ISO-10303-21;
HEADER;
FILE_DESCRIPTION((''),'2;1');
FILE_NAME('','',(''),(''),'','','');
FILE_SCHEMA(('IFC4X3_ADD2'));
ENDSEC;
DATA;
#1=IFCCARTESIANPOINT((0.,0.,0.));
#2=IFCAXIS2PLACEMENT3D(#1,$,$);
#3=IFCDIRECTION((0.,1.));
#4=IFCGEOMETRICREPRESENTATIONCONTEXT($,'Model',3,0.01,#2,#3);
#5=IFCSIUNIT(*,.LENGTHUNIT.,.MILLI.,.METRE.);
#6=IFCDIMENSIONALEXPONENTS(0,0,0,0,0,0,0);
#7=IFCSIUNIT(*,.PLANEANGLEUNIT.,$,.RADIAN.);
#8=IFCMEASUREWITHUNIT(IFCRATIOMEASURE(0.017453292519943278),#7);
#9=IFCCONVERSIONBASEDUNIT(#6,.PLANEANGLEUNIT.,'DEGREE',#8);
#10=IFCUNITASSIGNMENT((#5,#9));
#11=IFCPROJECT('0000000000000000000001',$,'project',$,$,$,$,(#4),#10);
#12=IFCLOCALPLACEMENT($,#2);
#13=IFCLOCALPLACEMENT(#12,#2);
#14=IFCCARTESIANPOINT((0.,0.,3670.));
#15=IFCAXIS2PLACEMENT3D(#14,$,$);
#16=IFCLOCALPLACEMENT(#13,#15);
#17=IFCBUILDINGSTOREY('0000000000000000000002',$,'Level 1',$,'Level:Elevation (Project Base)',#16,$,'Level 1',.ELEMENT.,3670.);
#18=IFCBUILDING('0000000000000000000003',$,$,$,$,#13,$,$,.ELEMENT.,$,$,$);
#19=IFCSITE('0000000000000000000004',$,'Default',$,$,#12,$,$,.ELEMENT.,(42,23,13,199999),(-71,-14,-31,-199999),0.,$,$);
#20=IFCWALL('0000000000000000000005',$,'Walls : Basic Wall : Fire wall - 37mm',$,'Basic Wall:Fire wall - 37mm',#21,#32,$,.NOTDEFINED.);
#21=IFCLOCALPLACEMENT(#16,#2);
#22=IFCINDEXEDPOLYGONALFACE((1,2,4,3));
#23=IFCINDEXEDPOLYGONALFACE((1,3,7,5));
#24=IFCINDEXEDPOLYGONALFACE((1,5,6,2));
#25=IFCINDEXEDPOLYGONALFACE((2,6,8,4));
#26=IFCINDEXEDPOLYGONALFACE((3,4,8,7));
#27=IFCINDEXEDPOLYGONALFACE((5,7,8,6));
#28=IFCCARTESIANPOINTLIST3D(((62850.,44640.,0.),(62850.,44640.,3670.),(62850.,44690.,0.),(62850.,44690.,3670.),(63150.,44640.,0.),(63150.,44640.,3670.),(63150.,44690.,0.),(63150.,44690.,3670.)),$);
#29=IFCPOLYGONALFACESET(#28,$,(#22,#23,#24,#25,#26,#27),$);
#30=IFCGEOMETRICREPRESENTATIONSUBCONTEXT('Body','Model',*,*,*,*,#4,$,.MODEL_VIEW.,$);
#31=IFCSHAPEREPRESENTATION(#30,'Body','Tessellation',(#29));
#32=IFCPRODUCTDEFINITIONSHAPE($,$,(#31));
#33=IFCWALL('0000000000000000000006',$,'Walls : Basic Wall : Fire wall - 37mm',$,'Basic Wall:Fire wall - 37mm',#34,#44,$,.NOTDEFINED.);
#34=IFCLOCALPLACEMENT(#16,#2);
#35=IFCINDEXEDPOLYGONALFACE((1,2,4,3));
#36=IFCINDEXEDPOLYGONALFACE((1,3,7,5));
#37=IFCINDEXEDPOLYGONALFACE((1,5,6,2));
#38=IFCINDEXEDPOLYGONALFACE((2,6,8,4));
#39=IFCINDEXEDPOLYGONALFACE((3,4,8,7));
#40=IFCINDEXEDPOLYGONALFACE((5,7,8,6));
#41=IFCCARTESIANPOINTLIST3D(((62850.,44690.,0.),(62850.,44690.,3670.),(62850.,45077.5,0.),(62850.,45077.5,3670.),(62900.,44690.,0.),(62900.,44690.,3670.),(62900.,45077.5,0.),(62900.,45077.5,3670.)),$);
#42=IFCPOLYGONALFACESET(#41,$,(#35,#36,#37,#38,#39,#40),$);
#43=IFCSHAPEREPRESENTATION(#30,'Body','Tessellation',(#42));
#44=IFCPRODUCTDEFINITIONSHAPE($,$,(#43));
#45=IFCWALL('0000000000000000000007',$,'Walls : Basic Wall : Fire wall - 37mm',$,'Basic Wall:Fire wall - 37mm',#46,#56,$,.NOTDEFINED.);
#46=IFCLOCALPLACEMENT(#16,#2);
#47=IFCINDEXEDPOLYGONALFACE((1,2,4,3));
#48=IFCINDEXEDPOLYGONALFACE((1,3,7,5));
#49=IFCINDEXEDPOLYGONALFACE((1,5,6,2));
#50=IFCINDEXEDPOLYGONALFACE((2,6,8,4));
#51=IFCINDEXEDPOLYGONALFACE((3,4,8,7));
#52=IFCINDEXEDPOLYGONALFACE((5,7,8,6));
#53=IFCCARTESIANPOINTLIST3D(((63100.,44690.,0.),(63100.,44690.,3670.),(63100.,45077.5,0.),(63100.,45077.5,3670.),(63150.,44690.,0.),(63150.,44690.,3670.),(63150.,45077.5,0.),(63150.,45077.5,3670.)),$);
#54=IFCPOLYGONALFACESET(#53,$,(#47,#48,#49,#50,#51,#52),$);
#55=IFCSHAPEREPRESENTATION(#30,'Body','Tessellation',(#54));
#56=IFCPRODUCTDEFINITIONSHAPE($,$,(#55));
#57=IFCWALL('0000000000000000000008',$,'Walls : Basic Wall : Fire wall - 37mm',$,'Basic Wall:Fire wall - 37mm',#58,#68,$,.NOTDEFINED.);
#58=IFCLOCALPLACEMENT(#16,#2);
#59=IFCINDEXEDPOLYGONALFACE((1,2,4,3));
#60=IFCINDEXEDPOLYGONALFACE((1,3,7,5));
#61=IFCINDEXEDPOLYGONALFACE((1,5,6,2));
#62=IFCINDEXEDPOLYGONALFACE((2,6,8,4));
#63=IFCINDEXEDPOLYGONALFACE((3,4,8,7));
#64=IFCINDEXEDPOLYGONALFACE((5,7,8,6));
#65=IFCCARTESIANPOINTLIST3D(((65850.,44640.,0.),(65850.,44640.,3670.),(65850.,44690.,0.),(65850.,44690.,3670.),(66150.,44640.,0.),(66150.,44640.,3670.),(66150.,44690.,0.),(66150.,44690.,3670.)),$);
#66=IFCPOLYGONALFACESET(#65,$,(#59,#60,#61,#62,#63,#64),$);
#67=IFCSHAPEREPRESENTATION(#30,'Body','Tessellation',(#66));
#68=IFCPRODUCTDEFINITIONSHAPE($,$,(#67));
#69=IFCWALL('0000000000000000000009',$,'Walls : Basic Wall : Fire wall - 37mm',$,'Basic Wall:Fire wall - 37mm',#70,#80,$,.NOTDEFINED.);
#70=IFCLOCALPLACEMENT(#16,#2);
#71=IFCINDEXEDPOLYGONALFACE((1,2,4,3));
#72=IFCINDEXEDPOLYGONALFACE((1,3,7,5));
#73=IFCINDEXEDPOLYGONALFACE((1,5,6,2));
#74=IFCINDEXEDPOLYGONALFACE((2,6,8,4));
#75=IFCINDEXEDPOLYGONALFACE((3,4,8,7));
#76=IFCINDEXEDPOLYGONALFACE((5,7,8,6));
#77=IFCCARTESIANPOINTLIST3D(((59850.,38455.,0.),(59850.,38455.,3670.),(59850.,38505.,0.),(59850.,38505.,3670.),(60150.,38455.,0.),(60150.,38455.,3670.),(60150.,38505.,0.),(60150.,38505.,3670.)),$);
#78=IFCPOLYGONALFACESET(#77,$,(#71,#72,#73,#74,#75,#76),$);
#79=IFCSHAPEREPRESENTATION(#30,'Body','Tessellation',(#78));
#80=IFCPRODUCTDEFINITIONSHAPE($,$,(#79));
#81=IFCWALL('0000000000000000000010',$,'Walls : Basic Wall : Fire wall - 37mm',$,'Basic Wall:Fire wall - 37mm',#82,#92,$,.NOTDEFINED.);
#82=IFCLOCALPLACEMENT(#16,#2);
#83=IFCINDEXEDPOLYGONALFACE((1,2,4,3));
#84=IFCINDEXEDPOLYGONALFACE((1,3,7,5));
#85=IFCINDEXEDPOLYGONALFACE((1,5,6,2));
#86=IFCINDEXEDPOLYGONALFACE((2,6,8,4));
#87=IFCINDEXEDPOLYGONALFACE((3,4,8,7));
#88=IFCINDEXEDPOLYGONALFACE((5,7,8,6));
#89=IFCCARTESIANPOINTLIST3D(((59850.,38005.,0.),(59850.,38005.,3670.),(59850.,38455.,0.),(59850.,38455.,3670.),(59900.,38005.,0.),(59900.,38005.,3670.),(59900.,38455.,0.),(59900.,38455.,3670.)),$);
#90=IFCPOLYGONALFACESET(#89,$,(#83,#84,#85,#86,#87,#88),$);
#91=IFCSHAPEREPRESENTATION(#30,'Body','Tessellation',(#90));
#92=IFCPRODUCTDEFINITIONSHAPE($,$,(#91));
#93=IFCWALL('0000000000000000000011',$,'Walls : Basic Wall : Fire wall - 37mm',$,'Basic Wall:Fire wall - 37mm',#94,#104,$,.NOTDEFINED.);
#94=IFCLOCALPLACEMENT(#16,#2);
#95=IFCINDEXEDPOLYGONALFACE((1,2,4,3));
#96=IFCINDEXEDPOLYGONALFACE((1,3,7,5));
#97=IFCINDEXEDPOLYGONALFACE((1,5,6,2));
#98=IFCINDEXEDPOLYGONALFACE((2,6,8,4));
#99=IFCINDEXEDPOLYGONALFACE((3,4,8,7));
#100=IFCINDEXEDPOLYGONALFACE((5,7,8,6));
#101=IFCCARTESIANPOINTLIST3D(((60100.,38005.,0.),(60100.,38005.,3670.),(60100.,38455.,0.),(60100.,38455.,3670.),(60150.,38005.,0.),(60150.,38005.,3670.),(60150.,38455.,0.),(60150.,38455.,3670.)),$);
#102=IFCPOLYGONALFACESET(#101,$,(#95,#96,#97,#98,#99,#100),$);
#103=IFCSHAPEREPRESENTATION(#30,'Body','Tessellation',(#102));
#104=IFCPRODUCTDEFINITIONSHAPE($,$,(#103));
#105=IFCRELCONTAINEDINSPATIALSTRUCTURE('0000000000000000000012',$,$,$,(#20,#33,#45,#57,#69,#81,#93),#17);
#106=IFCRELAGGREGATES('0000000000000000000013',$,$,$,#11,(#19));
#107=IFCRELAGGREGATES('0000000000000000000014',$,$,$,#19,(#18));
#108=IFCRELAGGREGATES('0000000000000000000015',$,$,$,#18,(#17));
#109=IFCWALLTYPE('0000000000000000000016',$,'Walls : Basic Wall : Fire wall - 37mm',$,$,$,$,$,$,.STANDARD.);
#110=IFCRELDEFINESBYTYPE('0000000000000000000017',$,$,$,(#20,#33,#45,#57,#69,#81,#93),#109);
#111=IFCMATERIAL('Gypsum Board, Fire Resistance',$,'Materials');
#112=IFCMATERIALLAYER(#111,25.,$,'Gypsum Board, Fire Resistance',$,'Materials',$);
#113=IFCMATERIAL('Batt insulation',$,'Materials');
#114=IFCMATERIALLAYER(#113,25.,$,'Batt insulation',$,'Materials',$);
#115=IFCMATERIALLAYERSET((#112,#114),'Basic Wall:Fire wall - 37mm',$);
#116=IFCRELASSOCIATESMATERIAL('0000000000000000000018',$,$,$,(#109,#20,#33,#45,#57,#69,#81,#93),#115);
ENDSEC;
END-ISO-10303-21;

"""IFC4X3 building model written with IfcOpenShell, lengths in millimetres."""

from ifc_helpers import new_model, entity, si_unit, converted_unit, direction, frame, frame_2d, origin, place, context, subcontext, project, spatial, rectangle, extrude, material, layer, layer_set, type_object, element, save


model = new_model("IFC4X3")

# Units and contexts
model_context = context("Model", 3, precision=0.01, world=origin(), true_north=direction((0.0, 1.0)))
body_context = subcontext(model_context, "Body", "Model", "MODEL_VIEW")
ifc_project = project(units=[si_unit("LENGTHUNIT", "METRE", prefix="MILLI"), converted_unit("PLANEANGLEUNIT", "DEGREE", entity("IfcRatioMeasure", 0.017453292519943278), si_unit("PLANEANGLEUNIT", "RADIAN"), dimensions=[0, 0, 0, 0, 0, 0, 0])], contexts=[model_context])

# Site, building, storey
site_placement = place(None, origin())
site = spatial("IfcSite", under=ifc_project, at=site_placement, Name="Default", CompositionType="ELEMENT", RefLatitude=(42, 23, 13, 199999), RefLongitude=(-71, -14, -31, -199999), RefElevation=0.0)
building_placement = place(site_placement, origin())
building = spatial("IfcBuilding", under=site, at=building_placement, CompositionType="ELEMENT")
storey_placement = place(building_placement, frame((0.0, 0.0, 3670.0)))
storey = spatial("IfcBuildingStorey", under=building, at=storey_placement, Name="Level 1", ObjectType="Level:Elevation (Project Base)", LongName="Level 1", CompositionType="ELEMENT", Elevation=3670.0)

# Walls
ifc_material_1 = material(Name="Gypsum Board, Fire Resistance", Category="Materials")
ifc_layer_1 = layer(ifc_material_1, 25.0, Name="Gypsum Board, Fire Resistance", Category="Materials")
ifc_material_2 = material(Name="Batt insulation", Category="Materials")
ifc_layer_2 = layer(ifc_material_2, 25.0, Name="Batt insulation", Category="Materials")
ifc_layer_set = layer_set([ifc_layer_1, ifc_layer_2], Name="Basic Wall:Fire wall - 37mm")
wall_type = type_object("IfcWallType", Name="Walls : Basic Wall : Fire wall - 37mm", PredefinedType="STANDARD", material=ifc_layer_set)
wall_1_placement = place(storey_placement, frame((62850.0, 44665.0, 0.0)))
element("IfcWall", 1, at=wall_1_placement, inside=storey, type_object=wall_type, material=ifc_layer_set, Name="Walls : Basic Wall : Fire wall - 37mm", ObjectType="Basic Wall:Fire wall - 37mm", PredefinedType="NOTDEFINED", context=body_context, shape_type="SweptSolid", body=[
    extrude(rectangle(XDim=300.0, YDim=50.0, at=frame_2d((150.0, 0.0), x_axis=(-1.0, 0.0))), origin(), (0.0, 0.0, 1.0), 3670.0),
])
for number, where, z_axis, x_axis, name in (
    (2, (62875.0, 45077.5, 0.0), (0.0, 0.0, 1.0), (0.0, -1.0, 0.0), "Walls : Basic Wall : Fire wall - 37mm"),
    (3, (63125.0, 45077.5, 0.0), (0.0, 0.0, 1.0), (0.0, -1.0, 0.0), "Walls : Basic Wall : Fire wall - 37mm"),
):
    element("IfcWall", number, at=place(storey_placement, frame(where, z_axis=z_axis, x_axis=x_axis)), inside=storey, type_object=wall_type, material=ifc_layer_set, Name=name, ObjectType="Basic Wall:Fire wall - 37mm", PredefinedType="NOTDEFINED", context=body_context, shape_type="SweptSolid", body=[
        extrude(rectangle(XDim=387.5, YDim=50.0, at=frame_2d((193.8, 0.0), x_axis=(-1.0, 0.0))), origin(), (0.0, 0.0, 1.0), 3670.0),
    ])
wall_2_placement = place(storey_placement, frame((65850.0, 44665.0, 0.0)))
element("IfcWall", 4, at=wall_2_placement, inside=storey, type_object=wall_type, material=ifc_layer_set, Name="Walls : Basic Wall : Fire wall - 37mm", ObjectType="Basic Wall:Fire wall - 37mm", PredefinedType="NOTDEFINED", context=body_context, shape_type="SweptSolid", body=[
    extrude(rectangle(XDim=300.0, YDim=50.0, at=frame_2d((150.0, 0.0), x_axis=(-1.0, 0.0))), origin(), (0.0, 0.0, 1.0), 3670.0),
])
wall_3_placement = place(storey_placement, frame((59850.0, 38480.0, 0.0)))
element("IfcWall", 5, at=wall_3_placement, inside=storey, type_object=wall_type, material=ifc_layer_set, Name="Walls : Basic Wall : Fire wall - 37mm", ObjectType="Basic Wall:Fire wall - 37mm", PredefinedType="NOTDEFINED", context=body_context, shape_type="SweptSolid", body=[
    extrude(rectangle(XDim=300.0, YDim=50.0, at=frame_2d((150.0, 0.0), x_axis=(-1.0, 0.0))), origin(), (0.0, 0.0, 1.0), 3670.0),
])
for number, where, z_axis, x_axis, name in (
    (6, (59875.0, 38455.0, 0.0), (0.0, 0.0, 1.0), (0.0, -1.0, 0.0), "Walls : Basic Wall : Fire wall - 37mm"),
    (7, (60125.0, 38455.0, 0.0), (0.0, 0.0, 1.0), (0.0, -1.0, 0.0), "Walls : Basic Wall : Fire wall - 37mm"),
):
    element("IfcWall", number, at=place(storey_placement, frame(where, z_axis=z_axis, x_axis=x_axis)), inside=storey, type_object=wall_type, material=ifc_layer_set, Name=name, ObjectType="Basic Wall:Fire wall - 37mm", PredefinedType="NOTDEFINED", context=body_context, shape_type="SweptSolid", body=[
        extrude(rectangle(XDim=450.0, YDim=50.0, at=frame_2d((225.0, 0.0), x_axis=(-1.0, 0.0))), origin(), (0.0, 0.0, 1.0), 3670.0),
    ])

save(model, "model.ifc")
